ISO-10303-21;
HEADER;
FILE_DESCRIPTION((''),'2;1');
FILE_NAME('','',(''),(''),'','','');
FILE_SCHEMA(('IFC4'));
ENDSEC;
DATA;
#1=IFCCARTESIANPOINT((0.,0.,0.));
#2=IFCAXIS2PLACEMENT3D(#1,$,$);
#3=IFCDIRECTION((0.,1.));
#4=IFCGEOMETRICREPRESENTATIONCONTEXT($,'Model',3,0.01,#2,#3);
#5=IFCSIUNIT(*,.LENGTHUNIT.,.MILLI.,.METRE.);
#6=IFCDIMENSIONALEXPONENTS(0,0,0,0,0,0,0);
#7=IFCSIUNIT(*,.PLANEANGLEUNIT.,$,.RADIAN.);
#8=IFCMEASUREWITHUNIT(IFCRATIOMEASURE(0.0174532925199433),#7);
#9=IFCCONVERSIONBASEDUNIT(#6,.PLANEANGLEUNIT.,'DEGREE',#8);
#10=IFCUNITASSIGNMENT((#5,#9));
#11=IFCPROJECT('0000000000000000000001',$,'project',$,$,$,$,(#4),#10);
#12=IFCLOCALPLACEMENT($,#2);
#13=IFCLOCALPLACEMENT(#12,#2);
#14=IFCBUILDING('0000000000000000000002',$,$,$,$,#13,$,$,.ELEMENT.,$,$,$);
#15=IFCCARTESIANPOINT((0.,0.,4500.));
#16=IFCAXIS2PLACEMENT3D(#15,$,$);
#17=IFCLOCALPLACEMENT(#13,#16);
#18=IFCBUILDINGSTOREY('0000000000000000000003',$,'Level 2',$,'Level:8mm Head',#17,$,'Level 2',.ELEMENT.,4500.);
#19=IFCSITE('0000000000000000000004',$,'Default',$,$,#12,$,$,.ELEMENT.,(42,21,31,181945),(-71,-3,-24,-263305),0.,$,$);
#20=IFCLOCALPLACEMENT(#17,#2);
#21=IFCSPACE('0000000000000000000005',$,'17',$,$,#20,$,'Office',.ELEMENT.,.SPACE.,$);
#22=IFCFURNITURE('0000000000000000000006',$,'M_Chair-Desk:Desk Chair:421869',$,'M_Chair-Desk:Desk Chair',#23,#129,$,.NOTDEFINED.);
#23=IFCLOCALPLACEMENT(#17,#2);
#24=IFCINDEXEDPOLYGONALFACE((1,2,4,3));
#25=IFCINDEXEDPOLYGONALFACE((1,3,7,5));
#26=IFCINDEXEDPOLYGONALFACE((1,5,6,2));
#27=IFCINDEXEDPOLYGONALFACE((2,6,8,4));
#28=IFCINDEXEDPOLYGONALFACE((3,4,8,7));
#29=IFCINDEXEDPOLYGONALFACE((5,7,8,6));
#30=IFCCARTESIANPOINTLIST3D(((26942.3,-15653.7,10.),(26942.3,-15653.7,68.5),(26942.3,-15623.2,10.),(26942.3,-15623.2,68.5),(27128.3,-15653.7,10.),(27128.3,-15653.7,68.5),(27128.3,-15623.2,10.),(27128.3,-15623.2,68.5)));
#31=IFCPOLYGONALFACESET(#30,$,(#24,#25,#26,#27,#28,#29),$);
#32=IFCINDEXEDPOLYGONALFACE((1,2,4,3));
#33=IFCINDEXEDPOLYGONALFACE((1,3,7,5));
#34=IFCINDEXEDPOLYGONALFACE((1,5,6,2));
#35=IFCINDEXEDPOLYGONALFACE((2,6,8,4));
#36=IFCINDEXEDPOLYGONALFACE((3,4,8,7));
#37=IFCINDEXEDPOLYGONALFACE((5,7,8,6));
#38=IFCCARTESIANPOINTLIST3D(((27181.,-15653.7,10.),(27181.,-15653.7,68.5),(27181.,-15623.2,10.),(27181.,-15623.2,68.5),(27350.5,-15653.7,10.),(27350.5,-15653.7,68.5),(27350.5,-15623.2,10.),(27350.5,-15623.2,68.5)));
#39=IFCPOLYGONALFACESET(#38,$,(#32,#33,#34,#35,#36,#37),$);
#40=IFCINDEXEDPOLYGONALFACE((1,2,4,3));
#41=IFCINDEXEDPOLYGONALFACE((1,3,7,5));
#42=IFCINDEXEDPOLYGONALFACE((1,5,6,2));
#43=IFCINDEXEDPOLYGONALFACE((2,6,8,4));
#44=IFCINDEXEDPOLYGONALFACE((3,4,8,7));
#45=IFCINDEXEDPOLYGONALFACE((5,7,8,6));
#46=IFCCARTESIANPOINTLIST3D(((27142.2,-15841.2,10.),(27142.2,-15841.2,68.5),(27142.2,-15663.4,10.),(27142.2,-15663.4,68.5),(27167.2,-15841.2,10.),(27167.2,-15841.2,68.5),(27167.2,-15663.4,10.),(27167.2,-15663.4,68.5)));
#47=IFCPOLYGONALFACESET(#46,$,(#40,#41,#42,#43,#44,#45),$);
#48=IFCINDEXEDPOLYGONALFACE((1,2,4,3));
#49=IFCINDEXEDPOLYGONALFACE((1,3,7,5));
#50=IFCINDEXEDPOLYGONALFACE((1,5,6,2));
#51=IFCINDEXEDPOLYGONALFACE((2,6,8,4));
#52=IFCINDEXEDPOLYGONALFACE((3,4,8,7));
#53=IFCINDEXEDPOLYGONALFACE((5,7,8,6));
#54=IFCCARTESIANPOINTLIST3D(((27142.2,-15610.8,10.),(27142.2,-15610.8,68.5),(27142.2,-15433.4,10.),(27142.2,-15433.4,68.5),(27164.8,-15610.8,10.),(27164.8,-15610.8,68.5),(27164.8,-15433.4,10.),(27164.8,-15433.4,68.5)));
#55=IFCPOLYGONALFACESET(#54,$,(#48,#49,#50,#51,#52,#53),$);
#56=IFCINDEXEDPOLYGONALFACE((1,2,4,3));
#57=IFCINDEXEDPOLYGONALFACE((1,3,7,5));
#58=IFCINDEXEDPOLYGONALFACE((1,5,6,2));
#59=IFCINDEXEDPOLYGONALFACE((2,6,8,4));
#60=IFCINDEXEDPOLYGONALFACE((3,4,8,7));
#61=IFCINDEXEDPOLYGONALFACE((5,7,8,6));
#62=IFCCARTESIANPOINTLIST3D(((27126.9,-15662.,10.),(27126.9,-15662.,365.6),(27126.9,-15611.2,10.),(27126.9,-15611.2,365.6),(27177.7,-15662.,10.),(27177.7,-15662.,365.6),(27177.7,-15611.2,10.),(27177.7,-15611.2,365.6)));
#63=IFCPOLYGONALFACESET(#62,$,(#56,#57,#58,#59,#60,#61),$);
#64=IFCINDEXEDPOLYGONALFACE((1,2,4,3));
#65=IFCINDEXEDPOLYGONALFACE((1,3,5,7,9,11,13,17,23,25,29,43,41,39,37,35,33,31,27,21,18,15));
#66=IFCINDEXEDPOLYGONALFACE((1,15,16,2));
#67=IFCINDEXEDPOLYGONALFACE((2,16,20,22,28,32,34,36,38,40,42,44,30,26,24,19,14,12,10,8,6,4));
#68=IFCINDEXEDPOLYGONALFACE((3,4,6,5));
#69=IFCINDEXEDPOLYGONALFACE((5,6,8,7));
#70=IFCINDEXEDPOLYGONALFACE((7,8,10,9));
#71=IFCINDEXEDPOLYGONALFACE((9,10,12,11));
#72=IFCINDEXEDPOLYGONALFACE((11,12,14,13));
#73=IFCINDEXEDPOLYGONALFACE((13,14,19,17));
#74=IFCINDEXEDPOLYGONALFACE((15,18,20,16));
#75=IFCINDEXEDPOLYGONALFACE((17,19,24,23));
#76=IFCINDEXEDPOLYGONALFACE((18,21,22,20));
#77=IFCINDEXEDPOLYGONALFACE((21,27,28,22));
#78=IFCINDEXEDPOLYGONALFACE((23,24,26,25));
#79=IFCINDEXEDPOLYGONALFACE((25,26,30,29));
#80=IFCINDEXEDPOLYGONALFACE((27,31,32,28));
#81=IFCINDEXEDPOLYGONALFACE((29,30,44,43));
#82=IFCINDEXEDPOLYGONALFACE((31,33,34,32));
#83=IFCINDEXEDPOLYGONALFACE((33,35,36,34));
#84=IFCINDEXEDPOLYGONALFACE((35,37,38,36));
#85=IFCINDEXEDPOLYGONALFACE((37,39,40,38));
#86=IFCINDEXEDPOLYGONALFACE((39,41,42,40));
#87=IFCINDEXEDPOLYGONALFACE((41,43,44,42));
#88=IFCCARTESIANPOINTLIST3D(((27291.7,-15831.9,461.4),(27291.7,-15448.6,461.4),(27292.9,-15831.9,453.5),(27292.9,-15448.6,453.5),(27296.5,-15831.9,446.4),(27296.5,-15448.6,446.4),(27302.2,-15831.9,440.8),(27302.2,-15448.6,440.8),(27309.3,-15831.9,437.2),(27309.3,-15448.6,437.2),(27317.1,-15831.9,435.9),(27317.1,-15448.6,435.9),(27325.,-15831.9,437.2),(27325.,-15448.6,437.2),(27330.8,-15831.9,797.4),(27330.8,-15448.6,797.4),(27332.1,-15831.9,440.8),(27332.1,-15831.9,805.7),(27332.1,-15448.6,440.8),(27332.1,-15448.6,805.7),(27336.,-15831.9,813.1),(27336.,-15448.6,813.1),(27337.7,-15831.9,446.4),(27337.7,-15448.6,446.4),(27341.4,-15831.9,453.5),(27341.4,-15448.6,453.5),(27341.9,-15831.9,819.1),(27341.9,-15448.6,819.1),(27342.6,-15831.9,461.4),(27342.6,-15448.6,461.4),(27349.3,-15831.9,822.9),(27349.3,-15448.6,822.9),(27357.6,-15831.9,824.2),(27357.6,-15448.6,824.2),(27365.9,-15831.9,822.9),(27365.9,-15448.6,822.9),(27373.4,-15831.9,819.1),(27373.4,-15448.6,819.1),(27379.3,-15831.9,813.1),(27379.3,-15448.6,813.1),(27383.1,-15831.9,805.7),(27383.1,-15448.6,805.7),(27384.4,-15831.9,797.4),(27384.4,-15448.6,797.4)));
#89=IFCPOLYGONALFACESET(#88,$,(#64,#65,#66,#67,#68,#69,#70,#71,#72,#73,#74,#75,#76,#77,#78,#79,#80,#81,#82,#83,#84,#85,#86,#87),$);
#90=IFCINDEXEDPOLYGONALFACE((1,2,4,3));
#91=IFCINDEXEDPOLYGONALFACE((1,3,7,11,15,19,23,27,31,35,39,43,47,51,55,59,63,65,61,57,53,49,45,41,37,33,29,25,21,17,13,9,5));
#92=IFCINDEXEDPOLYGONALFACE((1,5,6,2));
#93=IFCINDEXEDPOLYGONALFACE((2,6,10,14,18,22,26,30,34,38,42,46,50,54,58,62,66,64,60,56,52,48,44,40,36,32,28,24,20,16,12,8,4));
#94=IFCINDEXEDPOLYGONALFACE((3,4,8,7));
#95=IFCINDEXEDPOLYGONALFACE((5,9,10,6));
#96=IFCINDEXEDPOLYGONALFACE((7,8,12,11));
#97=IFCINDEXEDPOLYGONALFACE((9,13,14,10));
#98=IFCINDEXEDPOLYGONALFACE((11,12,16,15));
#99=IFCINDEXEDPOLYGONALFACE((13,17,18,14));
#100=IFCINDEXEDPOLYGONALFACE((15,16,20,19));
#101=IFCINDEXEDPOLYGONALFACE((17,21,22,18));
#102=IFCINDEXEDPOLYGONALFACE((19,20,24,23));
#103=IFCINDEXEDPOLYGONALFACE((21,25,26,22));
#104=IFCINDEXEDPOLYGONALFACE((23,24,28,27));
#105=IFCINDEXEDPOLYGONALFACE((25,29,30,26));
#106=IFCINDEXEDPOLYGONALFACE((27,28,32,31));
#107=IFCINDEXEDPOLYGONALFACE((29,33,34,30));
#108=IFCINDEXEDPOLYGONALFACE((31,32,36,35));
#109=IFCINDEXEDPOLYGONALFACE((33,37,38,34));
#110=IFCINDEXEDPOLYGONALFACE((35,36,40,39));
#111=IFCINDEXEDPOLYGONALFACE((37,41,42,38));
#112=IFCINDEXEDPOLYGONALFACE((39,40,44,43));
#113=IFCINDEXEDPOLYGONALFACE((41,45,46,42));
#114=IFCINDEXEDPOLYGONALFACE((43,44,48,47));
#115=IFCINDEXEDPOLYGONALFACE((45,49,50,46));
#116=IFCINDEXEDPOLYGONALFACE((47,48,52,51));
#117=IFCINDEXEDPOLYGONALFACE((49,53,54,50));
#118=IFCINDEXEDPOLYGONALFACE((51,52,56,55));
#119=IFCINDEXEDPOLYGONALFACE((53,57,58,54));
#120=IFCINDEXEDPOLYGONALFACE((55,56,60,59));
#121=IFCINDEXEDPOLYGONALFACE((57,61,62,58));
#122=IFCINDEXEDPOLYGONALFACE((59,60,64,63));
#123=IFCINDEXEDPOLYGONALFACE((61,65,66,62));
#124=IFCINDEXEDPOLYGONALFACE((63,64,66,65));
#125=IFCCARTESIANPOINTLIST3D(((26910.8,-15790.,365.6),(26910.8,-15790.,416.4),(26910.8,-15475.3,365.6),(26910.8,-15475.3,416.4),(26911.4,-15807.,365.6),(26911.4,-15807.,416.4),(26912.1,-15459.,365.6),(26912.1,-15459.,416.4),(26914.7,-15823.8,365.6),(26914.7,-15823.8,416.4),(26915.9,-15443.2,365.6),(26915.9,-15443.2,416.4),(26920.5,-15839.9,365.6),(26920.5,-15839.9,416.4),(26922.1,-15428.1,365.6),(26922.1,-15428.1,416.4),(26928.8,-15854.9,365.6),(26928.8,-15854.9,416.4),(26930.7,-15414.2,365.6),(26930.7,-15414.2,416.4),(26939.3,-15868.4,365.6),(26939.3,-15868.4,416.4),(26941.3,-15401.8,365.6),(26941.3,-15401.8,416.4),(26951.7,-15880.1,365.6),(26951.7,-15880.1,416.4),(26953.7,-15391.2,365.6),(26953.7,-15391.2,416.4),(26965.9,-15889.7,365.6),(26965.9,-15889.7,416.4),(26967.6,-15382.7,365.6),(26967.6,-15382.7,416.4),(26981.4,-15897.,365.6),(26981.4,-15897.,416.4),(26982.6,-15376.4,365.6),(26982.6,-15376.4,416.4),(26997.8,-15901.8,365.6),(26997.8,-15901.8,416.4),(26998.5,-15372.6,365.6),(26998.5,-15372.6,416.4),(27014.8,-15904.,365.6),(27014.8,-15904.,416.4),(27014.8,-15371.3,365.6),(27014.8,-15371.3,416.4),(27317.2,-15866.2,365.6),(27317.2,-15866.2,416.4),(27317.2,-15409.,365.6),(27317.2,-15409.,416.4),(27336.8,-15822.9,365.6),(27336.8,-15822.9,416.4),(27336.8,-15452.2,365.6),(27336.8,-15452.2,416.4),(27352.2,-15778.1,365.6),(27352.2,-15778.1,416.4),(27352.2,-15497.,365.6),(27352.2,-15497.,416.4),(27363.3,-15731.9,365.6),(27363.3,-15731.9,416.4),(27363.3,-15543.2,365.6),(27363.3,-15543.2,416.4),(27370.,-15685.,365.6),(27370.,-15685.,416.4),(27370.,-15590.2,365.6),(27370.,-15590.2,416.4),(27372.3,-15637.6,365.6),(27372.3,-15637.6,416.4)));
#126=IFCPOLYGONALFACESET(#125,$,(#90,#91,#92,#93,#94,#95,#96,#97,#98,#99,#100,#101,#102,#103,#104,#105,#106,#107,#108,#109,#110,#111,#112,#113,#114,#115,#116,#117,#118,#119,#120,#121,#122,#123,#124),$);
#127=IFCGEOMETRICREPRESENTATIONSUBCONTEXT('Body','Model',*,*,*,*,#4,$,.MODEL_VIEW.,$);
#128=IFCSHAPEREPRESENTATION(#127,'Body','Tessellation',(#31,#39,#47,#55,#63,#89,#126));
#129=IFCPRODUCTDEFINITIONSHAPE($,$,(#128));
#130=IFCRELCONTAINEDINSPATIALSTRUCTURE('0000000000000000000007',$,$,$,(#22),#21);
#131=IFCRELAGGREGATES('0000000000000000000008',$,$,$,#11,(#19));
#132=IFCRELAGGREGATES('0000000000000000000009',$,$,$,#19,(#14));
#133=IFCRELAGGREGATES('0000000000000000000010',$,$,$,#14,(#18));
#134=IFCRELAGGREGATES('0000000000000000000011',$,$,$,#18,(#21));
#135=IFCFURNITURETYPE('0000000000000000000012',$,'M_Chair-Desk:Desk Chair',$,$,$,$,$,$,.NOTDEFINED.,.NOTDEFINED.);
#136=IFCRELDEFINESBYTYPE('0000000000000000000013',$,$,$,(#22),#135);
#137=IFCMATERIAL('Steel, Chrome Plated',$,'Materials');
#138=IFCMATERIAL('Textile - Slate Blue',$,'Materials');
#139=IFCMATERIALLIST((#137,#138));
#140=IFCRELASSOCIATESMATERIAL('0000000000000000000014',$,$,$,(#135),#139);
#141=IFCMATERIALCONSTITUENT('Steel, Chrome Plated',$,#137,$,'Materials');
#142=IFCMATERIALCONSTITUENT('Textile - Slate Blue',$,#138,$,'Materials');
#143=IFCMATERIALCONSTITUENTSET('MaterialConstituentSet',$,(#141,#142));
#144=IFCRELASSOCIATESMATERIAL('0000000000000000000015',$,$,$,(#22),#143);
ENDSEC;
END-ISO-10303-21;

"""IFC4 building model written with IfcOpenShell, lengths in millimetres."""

from ifc_helpers import new_model, entity, si_unit, converted_unit, direction, frame, origin, place, context, subcontext, project, spatial, indexed_curve, outline, extrude, source, transform, mapped, material, material_list, constituent, constituent_set, type_object, type_shapes, element, save


model = new_model("IFC4")

# Units and contexts
model_context = context("Model", 3, precision=0.01, world=origin(), true_north=direction((0.0, 1.0)))
body_context = subcontext(model_context, "Body", "Model", "MODEL_VIEW")
ifc_project = project(units=[si_unit("LENGTHUNIT", "METRE", prefix="MILLI"), converted_unit("PLANEANGLEUNIT", "DEGREE", entity("IfcRatioMeasure", 0.0174532925199433), si_unit("PLANEANGLEUNIT", "RADIAN"), dimensions=[0, 0, 0, 0, 0, 0, 0])], contexts=[model_context])

# Site, building, storey
site_placement = place(None, origin())
site = spatial("IfcSite", under=ifc_project, at=site_placement, Name="Default", CompositionType="ELEMENT", RefLatitude=(42, 21, 31, 181945), RefLongitude=(-71, -3, -24, -263305), RefElevation=0.0)
building_placement = place(site_placement, origin())
building = spatial("IfcBuilding", under=site, at=building_placement, CompositionType="ELEMENT")
storey_placement = place(building_placement, frame((0.0, 0.0, 4500.0)))
storey = spatial("IfcBuildingStorey", under=building, at=storey_placement, Name="Level 2", ObjectType="Level:8mm Head", LongName="Level 2", CompositionType="ELEMENT", Elevation=4500.0)

# Shared definitions
space_placement = place(storey_placement, origin())
space = spatial("IfcSpace", under=storey, at=space_placement, Name="17", LongName="Office", CompositionType="ELEMENT", PredefinedType="SPACE")

# Furniture
ifc_material_1 = material(Name="Steel, Chrome Plated", Category="Materials")
ifc_constituent_1 = constituent(ifc_material_1, Name="Steel, Chrome Plated", Category="Materials")
ifc_material_2 = material(Name="Textile - Slate Blue", Category="Materials")
ifc_constituent_2 = constituent(ifc_material_2, Name="Textile - Slate Blue", Category="Materials")
ifc_constituent_set_1 = constituent_set(constituents=[ifc_constituent_1, ifc_constituent_2], Name="MaterialConstituentSet")
ifc_material_list_1 = material_list([ifc_material_1, ifc_material_2])
furniture_type = type_object("IfcFurnitureType", Name="M_Chair-Desk:Desk Chair", AssemblyPlace="NOTDEFINED", PredefinedType="NOTDEFINED", material=ifc_material_list_1)
shared_shape_1 = source(origin(), body_context, "Body", "SweptSolid", [
    extrude(outline(indexed_curve([(-15.2, -93.0), (15.2, -93.0), (15.2, 93.0), (-15.2, 93.0), (-15.2, -93.0)], self_intersect=False)), frame((-0.9, 281.9, 0.0)), (0.0, 0.0, 1.0), 58.5),
    extrude(outline(indexed_curve([(-15.2, -84.7), (15.2, -84.7), (15.2, 84.7), (-15.2, 84.7), (-15.2, -84.7)], self_intersect=False)), frame((-0.9, 51.5, 0.0), z_axis=(0.0, 0.0, 1.0), x_axis=(-1.0, 0.0, 0.0)), (0.0, 0.0, 1.0), 58.5),
    extrude(outline(indexed_curve([(-12.5, -88.9), (12.5, -88.9), (12.5, 88.9), (-12.5, 88.9), (-12.5, -88.9)], self_intersect=False)), frame((-114.8, 162.5, 0.0), z_axis=(0.0, 0.0, 1.0), x_axis=(0.0, -1.0, 0.0)), (0.0, 0.0, 1.0), 58.5),
    extrude(outline(indexed_curve([(-88.7, -11.3), (88.7, -11.3), (88.7, 11.3), (-88.7, 11.3), (-88.7, -11.3)], self_intersect=False)), frame((115.5, 163.7, 0.0), z_axis=(0.0, 0.0, 1.0), x_axis=(-1.0, 0.0, 0.0)), (0.0, 0.0, 1.0), 58.5),
    extrude(outline(indexed_curve([(-25.4, -25.4), (25.4, -25.4), (25.4, 25.4), (-25.4, 25.4), (-25.4, -25.4)], self_intersect=False)), frame((0.9, 164.9, 0.0), z_axis=(0.0, 0.0, 1.0), x_axis=(-1.0, 0.0, 0.0)), (0.0, 0.0, 1.0), 355.6),
    extrude(outline(indexed_curve([(6.5, 168.0), (5.2, 176.3), (1.4, 183.8), (-4.5, 189.7), (-12.0, 193.5), (-20.2, 194.8), (-28.5, 193.5), (-36.0, 189.7), (-41.9, 183.8), (-45.7, 176.3), (-47.0, 168.0), (-5.2, -168.0), (-4.0, -175.9), (-0.4, -183.0), (5.3, -188.6), (12.4, -192.2), (20.2, -193.5), (28.1, -192.2), (35.2, -188.6), (40.9, -183.0), (44.5, -175.9), (45.7, -168.0), (6.5, 168.0)], self_intersect=False)), frame((-194.4, -20.2, 619.4), z_axis=(1.0, 0.0, 0.0), x_axis=(0.0, 1.0, 0.0)), (0.0, 0.0, 1.0), 383.3),
    extrude(outline(indexed_curve([(-98.9, -257.7), (205.9, -257.7), (230.7, -217.3), (251.6, -174.7), (268.3, -130.3), (280.8, -84.5), (288.9, -37.7), (292.6, 9.6), (291.7, 57.0), (286.4, 104.2), (276.7, 150.6), (262.6, 195.9), (-32.8, 270.8), (-49.1, 271.5), (-65.3, 269.7), (-81.1, 265.4), (-95.9, 258.6), (-109.5, 249.7), (-121.6, 238.7), (-131.8, 225.9), (-139.8, 211.7), (-145.6, 196.5), (-148.9, 180.5), (-187.9, -131.7), (-189.4, -148.8), (-188.3, -165.8), (-184.5, -182.5), (-178.1, -198.4), (-169.4, -213.1), (-158.5, -226.2), (-145.6, -237.5), (-131.2, -246.7), (-115.5, -253.5), (-98.9, -257.7)], self_intersect=False)), frame((1.6, 236.3, 355.6), z_axis=(0.0, 0.0, 1.0), x_axis=(0.124035, -0.992278, 0.0)), (0.0, 0.0, 1.0), 50.8),
])
type_shapes(furniture_type, [shared_shape_1])
furniture_1_placement = place(space_placement, frame((27317.2, -15637.6, 10.0), z_axis=(0.0, 0.0, 1.0), x_axis=(0.0, 1.0, 0.0)))
element("IfcFurniture", 1, at=furniture_1_placement, inside=space, type_object=furniture_type, material=ifc_constituent_set_1, Name="M_Chair-Desk:Desk Chair:421869", ObjectType="M_Chair-Desk:Desk Chair", PredefinedType="NOTDEFINED", context=body_context, shape_type="MappedRepresentation", body=[
    mapped(shared_shape_1, transform((0.0, 0.0, 0.0), scale=1.0)),
])

save(model, "model.ifc")
